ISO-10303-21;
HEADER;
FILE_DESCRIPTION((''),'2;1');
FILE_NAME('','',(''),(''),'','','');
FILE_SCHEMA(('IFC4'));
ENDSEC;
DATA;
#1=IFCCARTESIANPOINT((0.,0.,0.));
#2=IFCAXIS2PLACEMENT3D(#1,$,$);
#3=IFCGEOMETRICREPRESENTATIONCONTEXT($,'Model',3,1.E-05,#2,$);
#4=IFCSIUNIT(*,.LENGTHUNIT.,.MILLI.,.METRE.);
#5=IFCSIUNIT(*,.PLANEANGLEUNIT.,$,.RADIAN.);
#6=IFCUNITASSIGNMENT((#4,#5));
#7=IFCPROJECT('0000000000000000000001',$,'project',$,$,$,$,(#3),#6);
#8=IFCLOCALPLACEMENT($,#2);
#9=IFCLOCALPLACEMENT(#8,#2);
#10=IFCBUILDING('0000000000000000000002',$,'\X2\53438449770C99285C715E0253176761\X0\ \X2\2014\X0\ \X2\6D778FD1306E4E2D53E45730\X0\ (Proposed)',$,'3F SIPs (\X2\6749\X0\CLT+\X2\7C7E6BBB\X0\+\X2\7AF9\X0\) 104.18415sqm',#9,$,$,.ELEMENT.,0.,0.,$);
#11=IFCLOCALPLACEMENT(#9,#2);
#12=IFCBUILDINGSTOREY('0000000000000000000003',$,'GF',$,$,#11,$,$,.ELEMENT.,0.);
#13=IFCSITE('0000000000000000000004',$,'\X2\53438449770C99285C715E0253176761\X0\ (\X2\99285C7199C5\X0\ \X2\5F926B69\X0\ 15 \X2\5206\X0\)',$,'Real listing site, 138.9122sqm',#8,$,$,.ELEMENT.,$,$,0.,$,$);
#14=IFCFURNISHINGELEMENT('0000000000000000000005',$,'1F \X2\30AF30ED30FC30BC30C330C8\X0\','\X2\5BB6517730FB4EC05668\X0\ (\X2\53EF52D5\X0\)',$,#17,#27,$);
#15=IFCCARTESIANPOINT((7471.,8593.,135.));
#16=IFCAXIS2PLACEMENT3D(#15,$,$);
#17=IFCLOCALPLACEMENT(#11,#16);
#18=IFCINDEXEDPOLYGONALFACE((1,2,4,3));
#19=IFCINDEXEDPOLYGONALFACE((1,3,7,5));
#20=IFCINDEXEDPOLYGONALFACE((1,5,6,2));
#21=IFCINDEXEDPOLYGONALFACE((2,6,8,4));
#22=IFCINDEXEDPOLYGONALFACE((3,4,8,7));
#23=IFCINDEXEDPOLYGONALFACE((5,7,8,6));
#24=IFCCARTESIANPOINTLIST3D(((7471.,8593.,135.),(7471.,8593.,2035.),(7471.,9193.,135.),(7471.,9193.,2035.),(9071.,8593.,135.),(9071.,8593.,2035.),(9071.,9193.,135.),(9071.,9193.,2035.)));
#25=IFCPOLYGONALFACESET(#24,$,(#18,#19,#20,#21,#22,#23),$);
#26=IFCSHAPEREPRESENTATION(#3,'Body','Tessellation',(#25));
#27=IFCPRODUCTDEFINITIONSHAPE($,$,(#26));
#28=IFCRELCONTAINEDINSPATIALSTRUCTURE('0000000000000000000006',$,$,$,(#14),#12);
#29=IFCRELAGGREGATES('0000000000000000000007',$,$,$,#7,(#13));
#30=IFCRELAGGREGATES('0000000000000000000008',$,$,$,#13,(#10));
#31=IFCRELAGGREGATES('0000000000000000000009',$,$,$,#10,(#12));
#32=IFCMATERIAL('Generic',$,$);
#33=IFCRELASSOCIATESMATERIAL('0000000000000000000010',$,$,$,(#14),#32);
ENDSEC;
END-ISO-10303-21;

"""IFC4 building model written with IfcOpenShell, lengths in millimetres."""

from ifc_helpers import new_model, si_unit, frame, frame_2d, origin, place, context, project, spatial, rectangle, extrude, material, element, save


model = new_model("IFC4")

# Units and contexts
model_context = context("Model", 3, precision=1e-05, world=origin())
ifc_project = project(units=[si_unit("LENGTHUNIT", "METRE", prefix="MILLI"), si_unit("PLANEANGLEUNIT", "RADIAN")], contexts=[model_context])

# Site, building, storey
site_placement = place(None, origin())
site = spatial("IfcSite", under=ifc_project, at=site_placement, Name="千葉県館山市北条 (館山駅 徒歩 15 分)", ObjectType="Real listing site, 138.9122sqm", CompositionType="ELEMENT", RefElevation=0.0)
building_placement = place(site_placement, origin())
building = spatial("IfcBuilding", under=site, at=building_placement, Name="千葉県館山市北条 — 海近の中古地 (Proposed)", ObjectType="3F SIPs (杉CLT+籾殻+竹) 104.18415sqm", CompositionType="ELEMENT", ElevationOfRefHeight=0.0, ElevationOfTerrain=0.0)
storey_placement = place(building_placement, origin())
storey = spatial("IfcBuildingStorey", under=building, at=storey_placement, Name="GF", CompositionType="ELEMENT", Elevation=0.0)

# Shared definitions
ifc_material_1 = material(Name="Generic")

# Furnishing element
furnishing_placement = place(storey_placement, frame((7471.0, 8593.0, 135.0)))
element("IfcFurnishingElement", 1, at=furnishing_placement, inside=storey, material=ifc_material_1, Name="1F クローゼット", Description="家具・什器 (可動)", context=model_context, shape_type="SweptSolid", body=[
    extrude(rectangle(XDim=1600.0, YDim=600.0, at=frame_2d((800.0, 300.0))), frame((7471.0, 8593.0, 135.0)), (0.0, 0.0, 1.0), 1900.0),
])

save(model, "model.ifc")
